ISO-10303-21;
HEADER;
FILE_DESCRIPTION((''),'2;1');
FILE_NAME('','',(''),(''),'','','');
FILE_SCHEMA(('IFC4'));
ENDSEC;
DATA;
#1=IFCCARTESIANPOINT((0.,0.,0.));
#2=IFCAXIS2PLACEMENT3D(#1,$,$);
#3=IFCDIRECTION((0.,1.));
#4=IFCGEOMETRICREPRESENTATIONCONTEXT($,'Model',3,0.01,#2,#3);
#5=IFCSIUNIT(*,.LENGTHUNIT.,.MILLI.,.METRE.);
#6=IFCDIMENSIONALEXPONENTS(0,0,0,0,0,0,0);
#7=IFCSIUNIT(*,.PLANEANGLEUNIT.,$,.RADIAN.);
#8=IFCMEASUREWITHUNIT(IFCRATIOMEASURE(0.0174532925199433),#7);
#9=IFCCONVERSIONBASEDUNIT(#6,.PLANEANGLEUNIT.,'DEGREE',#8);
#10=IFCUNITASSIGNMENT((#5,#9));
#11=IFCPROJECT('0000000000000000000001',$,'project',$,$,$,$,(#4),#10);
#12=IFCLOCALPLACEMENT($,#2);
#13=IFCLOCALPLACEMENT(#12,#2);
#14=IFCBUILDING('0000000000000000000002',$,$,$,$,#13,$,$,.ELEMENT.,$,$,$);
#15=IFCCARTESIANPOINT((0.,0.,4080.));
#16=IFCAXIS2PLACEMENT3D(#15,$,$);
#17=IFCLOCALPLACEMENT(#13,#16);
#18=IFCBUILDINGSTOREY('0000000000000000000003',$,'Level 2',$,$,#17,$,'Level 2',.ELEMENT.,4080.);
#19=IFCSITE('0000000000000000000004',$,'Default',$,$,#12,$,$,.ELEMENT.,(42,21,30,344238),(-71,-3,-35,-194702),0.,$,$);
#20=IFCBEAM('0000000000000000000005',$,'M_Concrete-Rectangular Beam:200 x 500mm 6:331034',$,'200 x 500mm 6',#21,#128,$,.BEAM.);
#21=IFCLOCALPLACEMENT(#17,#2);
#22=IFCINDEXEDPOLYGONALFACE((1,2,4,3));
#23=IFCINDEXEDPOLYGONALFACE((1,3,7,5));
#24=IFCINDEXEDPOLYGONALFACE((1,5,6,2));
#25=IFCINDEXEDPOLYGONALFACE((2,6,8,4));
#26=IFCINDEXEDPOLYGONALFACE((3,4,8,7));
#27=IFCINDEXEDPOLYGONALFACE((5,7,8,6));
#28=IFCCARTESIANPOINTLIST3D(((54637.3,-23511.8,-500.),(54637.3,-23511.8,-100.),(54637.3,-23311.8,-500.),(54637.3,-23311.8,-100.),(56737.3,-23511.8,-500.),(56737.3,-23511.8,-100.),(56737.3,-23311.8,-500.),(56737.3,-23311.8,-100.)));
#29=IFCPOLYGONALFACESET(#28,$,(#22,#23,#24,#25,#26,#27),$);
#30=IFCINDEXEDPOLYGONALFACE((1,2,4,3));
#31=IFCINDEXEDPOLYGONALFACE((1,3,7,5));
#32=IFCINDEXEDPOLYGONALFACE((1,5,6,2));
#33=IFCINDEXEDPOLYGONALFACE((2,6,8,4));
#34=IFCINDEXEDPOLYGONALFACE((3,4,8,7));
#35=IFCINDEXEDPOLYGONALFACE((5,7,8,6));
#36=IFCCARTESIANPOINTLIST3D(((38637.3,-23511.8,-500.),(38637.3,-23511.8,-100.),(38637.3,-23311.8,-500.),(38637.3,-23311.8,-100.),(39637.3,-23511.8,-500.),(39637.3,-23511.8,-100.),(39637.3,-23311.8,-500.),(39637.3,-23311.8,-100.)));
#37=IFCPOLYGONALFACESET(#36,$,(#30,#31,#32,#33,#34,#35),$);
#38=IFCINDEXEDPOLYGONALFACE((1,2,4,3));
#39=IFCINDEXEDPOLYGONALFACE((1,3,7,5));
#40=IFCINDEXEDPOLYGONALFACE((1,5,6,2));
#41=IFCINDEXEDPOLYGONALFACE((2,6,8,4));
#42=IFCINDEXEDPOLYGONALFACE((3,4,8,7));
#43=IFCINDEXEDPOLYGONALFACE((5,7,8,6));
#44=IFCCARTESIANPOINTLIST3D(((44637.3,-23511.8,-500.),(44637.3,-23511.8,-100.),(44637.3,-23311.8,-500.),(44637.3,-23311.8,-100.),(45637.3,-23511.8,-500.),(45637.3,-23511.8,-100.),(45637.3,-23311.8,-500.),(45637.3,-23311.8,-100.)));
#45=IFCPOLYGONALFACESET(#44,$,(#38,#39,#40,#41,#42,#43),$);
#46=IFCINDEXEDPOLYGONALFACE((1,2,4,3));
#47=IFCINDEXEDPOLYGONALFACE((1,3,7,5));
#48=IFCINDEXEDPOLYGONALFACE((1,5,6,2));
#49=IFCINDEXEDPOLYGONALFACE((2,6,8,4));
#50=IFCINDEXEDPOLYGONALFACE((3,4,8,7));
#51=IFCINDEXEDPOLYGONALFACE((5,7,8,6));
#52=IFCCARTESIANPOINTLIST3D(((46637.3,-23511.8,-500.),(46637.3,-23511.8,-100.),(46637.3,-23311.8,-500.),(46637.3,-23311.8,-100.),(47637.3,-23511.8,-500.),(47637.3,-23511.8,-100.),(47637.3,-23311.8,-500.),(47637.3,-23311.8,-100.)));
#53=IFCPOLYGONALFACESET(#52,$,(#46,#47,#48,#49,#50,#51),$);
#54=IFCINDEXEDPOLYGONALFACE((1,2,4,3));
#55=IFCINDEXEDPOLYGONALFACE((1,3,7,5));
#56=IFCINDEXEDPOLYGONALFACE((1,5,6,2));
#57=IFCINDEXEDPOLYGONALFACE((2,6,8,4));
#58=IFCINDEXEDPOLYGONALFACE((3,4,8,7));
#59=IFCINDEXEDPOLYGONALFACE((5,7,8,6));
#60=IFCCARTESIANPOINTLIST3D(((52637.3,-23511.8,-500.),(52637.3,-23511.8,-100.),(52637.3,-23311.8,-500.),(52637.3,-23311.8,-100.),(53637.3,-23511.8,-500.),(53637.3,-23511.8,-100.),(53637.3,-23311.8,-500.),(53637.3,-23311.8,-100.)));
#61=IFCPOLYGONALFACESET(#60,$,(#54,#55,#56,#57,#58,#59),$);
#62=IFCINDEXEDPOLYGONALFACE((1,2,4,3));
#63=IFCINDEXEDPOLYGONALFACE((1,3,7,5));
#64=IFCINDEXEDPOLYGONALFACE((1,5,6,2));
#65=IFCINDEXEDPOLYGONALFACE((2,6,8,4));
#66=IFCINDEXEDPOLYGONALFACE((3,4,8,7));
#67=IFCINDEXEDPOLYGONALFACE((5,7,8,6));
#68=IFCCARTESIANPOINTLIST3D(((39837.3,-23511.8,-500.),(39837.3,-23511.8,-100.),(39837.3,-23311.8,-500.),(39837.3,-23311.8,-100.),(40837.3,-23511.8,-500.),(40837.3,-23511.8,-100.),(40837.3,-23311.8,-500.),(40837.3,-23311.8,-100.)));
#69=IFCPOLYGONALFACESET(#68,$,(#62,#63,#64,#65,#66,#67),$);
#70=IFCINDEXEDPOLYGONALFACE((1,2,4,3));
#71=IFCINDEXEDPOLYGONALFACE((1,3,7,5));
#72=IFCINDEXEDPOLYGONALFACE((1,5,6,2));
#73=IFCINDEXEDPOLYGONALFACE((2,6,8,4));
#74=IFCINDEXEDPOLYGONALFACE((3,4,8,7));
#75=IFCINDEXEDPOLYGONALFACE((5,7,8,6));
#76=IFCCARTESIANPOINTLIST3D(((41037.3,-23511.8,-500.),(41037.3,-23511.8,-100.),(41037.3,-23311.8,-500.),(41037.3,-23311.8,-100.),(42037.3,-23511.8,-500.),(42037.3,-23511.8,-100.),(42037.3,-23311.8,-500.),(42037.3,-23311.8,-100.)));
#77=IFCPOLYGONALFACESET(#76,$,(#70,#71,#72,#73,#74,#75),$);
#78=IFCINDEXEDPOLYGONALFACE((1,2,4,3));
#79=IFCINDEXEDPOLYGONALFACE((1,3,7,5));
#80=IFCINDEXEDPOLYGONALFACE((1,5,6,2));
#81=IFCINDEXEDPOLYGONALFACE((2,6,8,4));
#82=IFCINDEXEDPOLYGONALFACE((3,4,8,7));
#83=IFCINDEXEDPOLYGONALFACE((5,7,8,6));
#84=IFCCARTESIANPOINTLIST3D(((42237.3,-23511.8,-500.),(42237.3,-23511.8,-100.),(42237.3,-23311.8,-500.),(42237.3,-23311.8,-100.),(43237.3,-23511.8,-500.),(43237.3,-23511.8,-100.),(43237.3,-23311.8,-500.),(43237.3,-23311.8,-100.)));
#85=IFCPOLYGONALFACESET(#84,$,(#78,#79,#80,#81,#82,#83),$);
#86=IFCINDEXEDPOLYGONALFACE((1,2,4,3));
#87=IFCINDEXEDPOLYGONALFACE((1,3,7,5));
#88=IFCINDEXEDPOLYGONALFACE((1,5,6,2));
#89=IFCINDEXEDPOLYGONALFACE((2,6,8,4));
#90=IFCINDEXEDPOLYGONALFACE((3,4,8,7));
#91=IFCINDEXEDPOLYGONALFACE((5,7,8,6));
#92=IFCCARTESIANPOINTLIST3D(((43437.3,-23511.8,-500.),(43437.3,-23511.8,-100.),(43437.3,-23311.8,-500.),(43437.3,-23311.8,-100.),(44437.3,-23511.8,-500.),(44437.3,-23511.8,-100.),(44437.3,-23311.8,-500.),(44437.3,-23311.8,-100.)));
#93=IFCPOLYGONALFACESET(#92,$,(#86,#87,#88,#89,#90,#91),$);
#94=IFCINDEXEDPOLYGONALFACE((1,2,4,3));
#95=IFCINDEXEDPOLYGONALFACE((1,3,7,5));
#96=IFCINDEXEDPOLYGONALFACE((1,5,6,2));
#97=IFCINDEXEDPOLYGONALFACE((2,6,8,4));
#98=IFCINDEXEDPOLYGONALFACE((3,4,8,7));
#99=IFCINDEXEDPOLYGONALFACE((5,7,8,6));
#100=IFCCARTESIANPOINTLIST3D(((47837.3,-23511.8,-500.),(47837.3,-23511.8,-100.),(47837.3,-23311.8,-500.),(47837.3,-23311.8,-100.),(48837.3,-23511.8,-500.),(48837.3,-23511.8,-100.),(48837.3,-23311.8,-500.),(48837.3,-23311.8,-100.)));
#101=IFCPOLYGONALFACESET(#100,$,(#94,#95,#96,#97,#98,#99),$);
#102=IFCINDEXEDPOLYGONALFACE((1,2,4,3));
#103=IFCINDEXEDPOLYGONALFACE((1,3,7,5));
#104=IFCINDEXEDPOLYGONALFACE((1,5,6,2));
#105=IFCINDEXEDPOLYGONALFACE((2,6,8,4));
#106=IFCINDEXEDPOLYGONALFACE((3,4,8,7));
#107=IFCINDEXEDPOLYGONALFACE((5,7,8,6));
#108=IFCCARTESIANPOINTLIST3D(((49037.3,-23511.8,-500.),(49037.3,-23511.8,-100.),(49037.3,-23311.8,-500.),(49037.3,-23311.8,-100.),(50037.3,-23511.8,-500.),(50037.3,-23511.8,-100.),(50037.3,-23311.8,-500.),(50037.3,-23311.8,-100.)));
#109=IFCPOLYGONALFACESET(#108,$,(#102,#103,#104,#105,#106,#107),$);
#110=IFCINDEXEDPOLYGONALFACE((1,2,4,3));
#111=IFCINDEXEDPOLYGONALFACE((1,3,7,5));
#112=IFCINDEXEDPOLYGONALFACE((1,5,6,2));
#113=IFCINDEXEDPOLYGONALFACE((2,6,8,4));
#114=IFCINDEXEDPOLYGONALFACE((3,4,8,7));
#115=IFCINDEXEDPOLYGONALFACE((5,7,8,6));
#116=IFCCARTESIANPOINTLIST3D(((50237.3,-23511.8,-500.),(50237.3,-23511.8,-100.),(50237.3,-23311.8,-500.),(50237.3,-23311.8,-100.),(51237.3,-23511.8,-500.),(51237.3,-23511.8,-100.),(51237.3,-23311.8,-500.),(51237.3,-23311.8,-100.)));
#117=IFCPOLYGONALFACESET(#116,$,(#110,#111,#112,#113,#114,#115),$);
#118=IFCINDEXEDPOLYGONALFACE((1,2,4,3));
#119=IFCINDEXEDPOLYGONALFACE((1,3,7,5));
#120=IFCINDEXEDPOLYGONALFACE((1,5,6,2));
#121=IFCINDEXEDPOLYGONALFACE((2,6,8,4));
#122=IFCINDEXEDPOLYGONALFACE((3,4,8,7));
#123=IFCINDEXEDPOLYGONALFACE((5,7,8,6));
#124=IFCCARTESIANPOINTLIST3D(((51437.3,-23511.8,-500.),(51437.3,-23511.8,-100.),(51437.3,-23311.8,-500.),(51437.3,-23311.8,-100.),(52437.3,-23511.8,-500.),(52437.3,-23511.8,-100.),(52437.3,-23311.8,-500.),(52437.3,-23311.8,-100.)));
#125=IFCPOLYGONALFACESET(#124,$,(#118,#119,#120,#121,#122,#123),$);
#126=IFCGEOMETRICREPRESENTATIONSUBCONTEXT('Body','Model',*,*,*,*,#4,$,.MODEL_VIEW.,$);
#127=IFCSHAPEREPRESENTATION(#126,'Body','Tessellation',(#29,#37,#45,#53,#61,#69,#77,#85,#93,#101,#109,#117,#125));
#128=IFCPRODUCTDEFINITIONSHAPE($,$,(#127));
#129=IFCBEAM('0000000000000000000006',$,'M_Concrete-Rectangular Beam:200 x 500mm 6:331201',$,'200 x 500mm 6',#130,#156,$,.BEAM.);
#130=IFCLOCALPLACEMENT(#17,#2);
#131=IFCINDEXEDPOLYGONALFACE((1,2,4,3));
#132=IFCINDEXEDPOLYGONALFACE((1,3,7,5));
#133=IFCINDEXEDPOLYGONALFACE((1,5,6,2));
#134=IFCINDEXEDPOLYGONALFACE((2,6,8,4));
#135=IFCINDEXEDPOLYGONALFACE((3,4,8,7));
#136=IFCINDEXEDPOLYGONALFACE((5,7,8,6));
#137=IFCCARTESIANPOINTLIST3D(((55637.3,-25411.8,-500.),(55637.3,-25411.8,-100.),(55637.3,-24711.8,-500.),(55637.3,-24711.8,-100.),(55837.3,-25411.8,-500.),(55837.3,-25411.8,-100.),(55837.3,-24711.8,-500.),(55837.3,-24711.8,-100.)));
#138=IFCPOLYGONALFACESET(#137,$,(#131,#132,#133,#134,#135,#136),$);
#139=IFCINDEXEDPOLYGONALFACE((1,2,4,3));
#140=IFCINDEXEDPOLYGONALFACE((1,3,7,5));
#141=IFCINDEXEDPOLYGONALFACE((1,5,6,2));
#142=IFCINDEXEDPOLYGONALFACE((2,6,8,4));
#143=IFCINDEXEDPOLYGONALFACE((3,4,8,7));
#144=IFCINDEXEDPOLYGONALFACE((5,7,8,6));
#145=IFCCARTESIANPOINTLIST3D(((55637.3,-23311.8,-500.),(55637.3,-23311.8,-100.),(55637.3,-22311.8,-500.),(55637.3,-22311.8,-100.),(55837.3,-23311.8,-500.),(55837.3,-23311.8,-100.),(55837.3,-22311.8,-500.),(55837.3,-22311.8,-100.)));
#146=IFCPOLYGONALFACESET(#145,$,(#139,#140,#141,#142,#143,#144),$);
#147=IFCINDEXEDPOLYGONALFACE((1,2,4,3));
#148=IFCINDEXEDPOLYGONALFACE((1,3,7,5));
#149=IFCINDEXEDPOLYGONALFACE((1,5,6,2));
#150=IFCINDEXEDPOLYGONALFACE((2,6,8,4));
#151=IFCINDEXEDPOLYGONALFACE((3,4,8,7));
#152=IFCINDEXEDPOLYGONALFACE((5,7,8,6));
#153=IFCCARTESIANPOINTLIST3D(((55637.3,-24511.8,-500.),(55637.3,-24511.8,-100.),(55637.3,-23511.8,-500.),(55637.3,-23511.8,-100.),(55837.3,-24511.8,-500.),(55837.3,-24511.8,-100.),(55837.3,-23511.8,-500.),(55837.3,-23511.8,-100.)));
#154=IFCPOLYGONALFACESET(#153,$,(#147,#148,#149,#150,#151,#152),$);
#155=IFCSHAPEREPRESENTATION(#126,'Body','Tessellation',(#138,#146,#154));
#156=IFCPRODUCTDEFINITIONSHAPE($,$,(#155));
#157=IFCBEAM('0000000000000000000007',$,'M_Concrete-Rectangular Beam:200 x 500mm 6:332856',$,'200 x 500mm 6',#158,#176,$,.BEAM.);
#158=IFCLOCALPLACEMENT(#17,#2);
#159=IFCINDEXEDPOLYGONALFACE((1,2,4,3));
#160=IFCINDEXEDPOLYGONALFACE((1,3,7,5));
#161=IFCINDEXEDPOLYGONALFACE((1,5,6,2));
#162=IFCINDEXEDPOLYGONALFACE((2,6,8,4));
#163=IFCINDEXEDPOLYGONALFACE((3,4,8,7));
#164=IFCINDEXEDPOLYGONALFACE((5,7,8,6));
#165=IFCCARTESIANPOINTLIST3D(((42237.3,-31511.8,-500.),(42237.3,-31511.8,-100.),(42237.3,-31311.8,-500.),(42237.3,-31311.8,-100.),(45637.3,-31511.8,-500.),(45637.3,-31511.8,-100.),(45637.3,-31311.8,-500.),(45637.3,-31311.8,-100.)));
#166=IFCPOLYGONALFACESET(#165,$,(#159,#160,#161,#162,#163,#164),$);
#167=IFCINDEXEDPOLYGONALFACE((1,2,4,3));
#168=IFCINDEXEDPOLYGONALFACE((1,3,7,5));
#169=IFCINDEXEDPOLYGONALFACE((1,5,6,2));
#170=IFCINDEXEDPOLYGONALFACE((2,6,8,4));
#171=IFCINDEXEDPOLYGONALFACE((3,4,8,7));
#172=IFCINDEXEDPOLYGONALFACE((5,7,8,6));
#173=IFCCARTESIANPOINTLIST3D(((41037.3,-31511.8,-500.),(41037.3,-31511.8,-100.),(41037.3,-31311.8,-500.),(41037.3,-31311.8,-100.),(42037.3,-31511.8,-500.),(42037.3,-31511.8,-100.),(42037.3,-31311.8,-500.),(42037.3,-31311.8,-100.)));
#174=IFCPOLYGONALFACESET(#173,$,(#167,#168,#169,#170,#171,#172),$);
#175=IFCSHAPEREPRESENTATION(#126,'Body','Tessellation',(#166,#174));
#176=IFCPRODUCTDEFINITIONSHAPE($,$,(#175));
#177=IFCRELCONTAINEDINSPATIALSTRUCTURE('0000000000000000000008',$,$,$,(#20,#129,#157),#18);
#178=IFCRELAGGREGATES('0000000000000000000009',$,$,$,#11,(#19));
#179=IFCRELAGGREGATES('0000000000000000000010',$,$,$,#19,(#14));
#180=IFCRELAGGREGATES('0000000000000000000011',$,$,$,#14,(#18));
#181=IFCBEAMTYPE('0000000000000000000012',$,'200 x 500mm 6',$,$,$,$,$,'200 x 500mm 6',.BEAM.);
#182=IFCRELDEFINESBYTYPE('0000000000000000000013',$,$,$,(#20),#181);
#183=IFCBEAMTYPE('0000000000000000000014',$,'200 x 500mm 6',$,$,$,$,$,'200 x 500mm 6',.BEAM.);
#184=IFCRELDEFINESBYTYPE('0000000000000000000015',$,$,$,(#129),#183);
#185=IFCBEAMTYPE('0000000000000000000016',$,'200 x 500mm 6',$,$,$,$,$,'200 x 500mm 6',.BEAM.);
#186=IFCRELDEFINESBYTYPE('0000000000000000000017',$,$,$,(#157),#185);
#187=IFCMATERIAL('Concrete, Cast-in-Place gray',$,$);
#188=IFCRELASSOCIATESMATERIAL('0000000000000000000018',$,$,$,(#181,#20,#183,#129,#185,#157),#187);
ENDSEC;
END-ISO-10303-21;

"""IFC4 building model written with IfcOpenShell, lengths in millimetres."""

from ifc_helpers import new_model, entity, si_unit, converted_unit, direction, frame, frame_2d, origin, origin_2d_with_axis, place, context, subcontext, project, spatial, rectangle, extrude, source, transform, mapped, material, type_object, type_shapes, element, save


model = new_model("IFC4")

# Units and contexts
model_context = context("Model", 3, precision=0.01, world=origin(), true_north=direction((0.0, 1.0)))
body_context = subcontext(model_context, "Body", "Model", "MODEL_VIEW")
ifc_project = project(units=[si_unit("LENGTHUNIT", "METRE", prefix="MILLI"), converted_unit("PLANEANGLEUNIT", "DEGREE", entity("IfcRatioMeasure", 0.0174532925199433), si_unit("PLANEANGLEUNIT", "RADIAN"), dimensions=[0, 0, 0, 0, 0, 0, 0])], contexts=[model_context])

# Site, building, storey
site_placement = place(None, origin())
site = spatial("IfcSite", under=ifc_project, at=site_placement, Name="Default", CompositionType="ELEMENT", RefLatitude=(42, 21, 30, 344238), RefLongitude=(-71, -3, -35, -194702), RefElevation=0.0)
building_placement = place(site_placement, origin())
building = spatial("IfcBuilding", under=site, at=building_placement, CompositionType="ELEMENT")
storey_placement = place(building_placement, frame((0.0, 0.0, 4080.0)))
storey = spatial("IfcBuildingStorey", under=building, at=storey_placement, Name="Level 2", LongName="Level 2", CompositionType="ELEMENT", Elevation=4080.0)

# Beams
ifc_material_1 = material(Name="Concrete, Cast-in-Place gray")
beam_type_1 = type_object("IfcBeamType", Name="200 x 500mm 6", ElementType="200 x 500mm 6", PredefinedType="BEAM", material=ifc_material_1)
shared_shape_1 = source(origin(), body_context, "Body", "SweptSolid", [
    extrude(rectangle(XDim=2100.0, YDim=200.0, at=frame_2d((-170.0, 20.0), x_axis=(1.0, 0.0))), frame((55857.3, -23431.8, 3580.0)), (0.0, 0.0, 1.0), 400.0),
    extrude(rectangle(XDim=1000.0, YDim=200.0, at=frame_2d((0.0, 0.0), x_axis=(1.0, 0.0))), frame((39137.3, -23411.8, 3580.0)), (0.0, 0.0, 1.0), 400.0),
    extrude(rectangle(XDim=1000.0, YDim=200.0, at=frame_2d((0.0, 0.0), x_axis=(1.0, 0.0))), frame((45137.3, -23411.8, 3580.0), z_axis=(0.0, 0.0, 1.0), x_axis=(-1.0, 0.0, 0.0)), (0.0, 0.0, 1.0), 400.0),
    extrude(rectangle(XDim=1000.0, YDim=200.0, at=frame_2d((-133.3, 0.0), x_axis=(1.0, 0.0))), frame((47270.6, -23411.8, 3580.0)), (0.0, 0.0, 1.0), 400.0),
    extrude(rectangle(XDim=1000.0, YDim=200.0, at=frame_2d((0.0, 0.0), x_axis=(1.0, 0.0))), frame((53137.3, -23411.8, 3580.0), z_axis=(0.0, 0.0, 1.0), x_axis=(-1.0, 0.0, 0.0)), (0.0, 0.0, 1.0), 400.0),
    extrude(rectangle(XDim=1000.0, YDim=200.0, at=frame_2d((0.0, 0.0), x_axis=(1.0, 0.0))), frame((40337.3, -23411.8, 3580.0)), (0.0, 0.0, 1.0), 400.0),
    extrude(rectangle(XDim=1000.0, YDim=200.0, at=frame_2d((0.0, 0.0), x_axis=(1.0, 0.0))), frame((41537.3, -23411.8, 3580.0)), (0.0, 0.0, 1.0), 400.0),
    extrude(rectangle(XDim=1000.0, YDim=200.0, at=frame_2d((0.0, 0.0), x_axis=(1.0, 0.0))), frame((42737.3, -23411.8, 3580.0)), (0.0, 0.0, 1.0), 400.0),
    extrude(rectangle(XDim=1000.0, YDim=200.0, at=origin_2d_with_axis()), frame((43937.3, -23411.8, 3580.0)), (0.0, 0.0, 1.0), 400.0),
    extrude(rectangle(XDim=1000.0, YDim=200.0, at=frame_2d((0.0, 0.0), x_axis=(1.0, 0.0))), frame((48337.3, -23411.8, 3580.0)), (0.0, 0.0, 1.0), 400.0),
    extrude(rectangle(XDim=1000.0, YDim=200.0, at=frame_2d((0.0, 0.0), x_axis=(1.0, 0.0))), frame((49537.3, -23411.8, 3580.0)), (0.0, 0.0, 1.0), 400.0),
    extrude(rectangle(XDim=1000.0, YDim=200.0, at=frame_2d((0.0, 0.0), x_axis=(1.0, 0.0))), frame((50737.3, -23411.8, 3580.0)), (0.0, 0.0, 1.0), 400.0),
    extrude(rectangle(XDim=1000.0, YDim=200.0, at=frame_2d((0.0, 0.0), x_axis=(1.0, 0.0))), frame((51937.3, -23411.8, 3580.0)), (0.0, 0.0, 1.0), 400.0),
])
type_shapes(beam_type_1, [shared_shape_1])
beam_1_placement = place(storey_placement, frame((0.0, 0.0, -4080.0)))
element("IfcBeam", 1, at=beam_1_placement, inside=storey, type_object=beam_type_1, material=ifc_material_1, Name="M_Concrete-Rectangular Beam:200 x 500mm 6:331034", ObjectType="200 x 500mm 6", PredefinedType="BEAM", context=body_context, shape_type="MappedRepresentation", body=[
    mapped(shared_shape_1, transform((0.0, 0.0, 0.0), scale=1.0)),
])
beam_type_2 = type_object("IfcBeamType", Name="200 x 500mm 6", ElementType="200 x 500mm 6", PredefinedType="BEAM", material=ifc_material_1)
shared_shape_2 = source(origin(), body_context, "Body", "SweptSolid", [
    extrude(rectangle(XDim=700.0, YDim=200.0, at=frame_2d((0.0, 0.0), x_axis=(1.0, 0.0))), frame((55737.3, -25061.8, 3580.0), z_axis=(0.0, 0.0, 1.0), x_axis=(0.0, 1.0, 0.0)), (0.0, 0.0, 1.0), 400.0),
    extrude(rectangle(XDim=1000.0, YDim=200.0, at=frame_2d((0.0, 0.0), x_axis=(1.0, 0.0))), frame((55737.3, -22811.8, 3580.0), z_axis=(0.0, 0.0, 1.0), x_axis=(0.0, -1.0, 0.0)), (0.0, 0.0, 1.0), 400.0),
    extrude(rectangle(XDim=1000.0, YDim=200.0, at=frame_2d((0.0, 0.0), x_axis=(1.0, 0.0))), frame((55737.3, -24011.8, 3580.0), z_axis=(0.0, 0.0, 1.0), x_axis=(0.0, 1.0, 0.0)), (0.0, 0.0, 1.0), 400.0),
])
type_shapes(beam_type_2, [shared_shape_2])
beam_2_placement = place(storey_placement, frame((0.0, 0.0, -4080.0)))
element("IfcBeam", 2, at=beam_2_placement, inside=storey, type_object=beam_type_2, material=ifc_material_1, Name="M_Concrete-Rectangular Beam:200 x 500mm 6:331201", ObjectType="200 x 500mm 6", PredefinedType="BEAM", context=body_context, shape_type="MappedRepresentation", body=[
    mapped(shared_shape_2, transform((0.0, 0.0, 0.0), scale=1.0)),
])
beam_type_3 = type_object("IfcBeamType", Name="200 x 500mm 6", ElementType="200 x 500mm 6", PredefinedType="BEAM", material=ifc_material_1)
shared_shape_3 = source(origin(), body_context, "Body", "SweptSolid", [
    extrude(rectangle(XDim=3400.0, YDim=200.0, at=frame_2d((0.0, 0.0), x_axis=(1.0, 0.0))), frame((43937.3, -31411.8, 3580.0), z_axis=(0.0, 0.0, 1.0), x_axis=(-1.0, 0.0, 0.0)), (0.0, 0.0, 1.0), 400.0),
    extrude(rectangle(XDim=1000.0, YDim=200.0, at=frame_2d((0.0, 0.0), x_axis=(1.0, 0.0))), frame((41537.3, -31411.8, 3580.0)), (0.0, 0.0, 1.0), 400.0),
])
type_shapes(beam_type_3, [shared_shape_3])
beam_3_placement = place(storey_placement, frame((0.0, 0.0, -4080.0)))
element("IfcBeam", 3, at=beam_3_placement, inside=storey, type_object=beam_type_3, material=ifc_material_1, Name="M_Concrete-Rectangular Beam:200 x 500mm 6:332856", ObjectType="200 x 500mm 6", PredefinedType="BEAM", context=body_context, shape_type="MappedRepresentation", body=[
    mapped(shared_shape_3, transform((0.0, 0.0, 0.0), scale=1.0)),
])

save(model, "model.ifc")
